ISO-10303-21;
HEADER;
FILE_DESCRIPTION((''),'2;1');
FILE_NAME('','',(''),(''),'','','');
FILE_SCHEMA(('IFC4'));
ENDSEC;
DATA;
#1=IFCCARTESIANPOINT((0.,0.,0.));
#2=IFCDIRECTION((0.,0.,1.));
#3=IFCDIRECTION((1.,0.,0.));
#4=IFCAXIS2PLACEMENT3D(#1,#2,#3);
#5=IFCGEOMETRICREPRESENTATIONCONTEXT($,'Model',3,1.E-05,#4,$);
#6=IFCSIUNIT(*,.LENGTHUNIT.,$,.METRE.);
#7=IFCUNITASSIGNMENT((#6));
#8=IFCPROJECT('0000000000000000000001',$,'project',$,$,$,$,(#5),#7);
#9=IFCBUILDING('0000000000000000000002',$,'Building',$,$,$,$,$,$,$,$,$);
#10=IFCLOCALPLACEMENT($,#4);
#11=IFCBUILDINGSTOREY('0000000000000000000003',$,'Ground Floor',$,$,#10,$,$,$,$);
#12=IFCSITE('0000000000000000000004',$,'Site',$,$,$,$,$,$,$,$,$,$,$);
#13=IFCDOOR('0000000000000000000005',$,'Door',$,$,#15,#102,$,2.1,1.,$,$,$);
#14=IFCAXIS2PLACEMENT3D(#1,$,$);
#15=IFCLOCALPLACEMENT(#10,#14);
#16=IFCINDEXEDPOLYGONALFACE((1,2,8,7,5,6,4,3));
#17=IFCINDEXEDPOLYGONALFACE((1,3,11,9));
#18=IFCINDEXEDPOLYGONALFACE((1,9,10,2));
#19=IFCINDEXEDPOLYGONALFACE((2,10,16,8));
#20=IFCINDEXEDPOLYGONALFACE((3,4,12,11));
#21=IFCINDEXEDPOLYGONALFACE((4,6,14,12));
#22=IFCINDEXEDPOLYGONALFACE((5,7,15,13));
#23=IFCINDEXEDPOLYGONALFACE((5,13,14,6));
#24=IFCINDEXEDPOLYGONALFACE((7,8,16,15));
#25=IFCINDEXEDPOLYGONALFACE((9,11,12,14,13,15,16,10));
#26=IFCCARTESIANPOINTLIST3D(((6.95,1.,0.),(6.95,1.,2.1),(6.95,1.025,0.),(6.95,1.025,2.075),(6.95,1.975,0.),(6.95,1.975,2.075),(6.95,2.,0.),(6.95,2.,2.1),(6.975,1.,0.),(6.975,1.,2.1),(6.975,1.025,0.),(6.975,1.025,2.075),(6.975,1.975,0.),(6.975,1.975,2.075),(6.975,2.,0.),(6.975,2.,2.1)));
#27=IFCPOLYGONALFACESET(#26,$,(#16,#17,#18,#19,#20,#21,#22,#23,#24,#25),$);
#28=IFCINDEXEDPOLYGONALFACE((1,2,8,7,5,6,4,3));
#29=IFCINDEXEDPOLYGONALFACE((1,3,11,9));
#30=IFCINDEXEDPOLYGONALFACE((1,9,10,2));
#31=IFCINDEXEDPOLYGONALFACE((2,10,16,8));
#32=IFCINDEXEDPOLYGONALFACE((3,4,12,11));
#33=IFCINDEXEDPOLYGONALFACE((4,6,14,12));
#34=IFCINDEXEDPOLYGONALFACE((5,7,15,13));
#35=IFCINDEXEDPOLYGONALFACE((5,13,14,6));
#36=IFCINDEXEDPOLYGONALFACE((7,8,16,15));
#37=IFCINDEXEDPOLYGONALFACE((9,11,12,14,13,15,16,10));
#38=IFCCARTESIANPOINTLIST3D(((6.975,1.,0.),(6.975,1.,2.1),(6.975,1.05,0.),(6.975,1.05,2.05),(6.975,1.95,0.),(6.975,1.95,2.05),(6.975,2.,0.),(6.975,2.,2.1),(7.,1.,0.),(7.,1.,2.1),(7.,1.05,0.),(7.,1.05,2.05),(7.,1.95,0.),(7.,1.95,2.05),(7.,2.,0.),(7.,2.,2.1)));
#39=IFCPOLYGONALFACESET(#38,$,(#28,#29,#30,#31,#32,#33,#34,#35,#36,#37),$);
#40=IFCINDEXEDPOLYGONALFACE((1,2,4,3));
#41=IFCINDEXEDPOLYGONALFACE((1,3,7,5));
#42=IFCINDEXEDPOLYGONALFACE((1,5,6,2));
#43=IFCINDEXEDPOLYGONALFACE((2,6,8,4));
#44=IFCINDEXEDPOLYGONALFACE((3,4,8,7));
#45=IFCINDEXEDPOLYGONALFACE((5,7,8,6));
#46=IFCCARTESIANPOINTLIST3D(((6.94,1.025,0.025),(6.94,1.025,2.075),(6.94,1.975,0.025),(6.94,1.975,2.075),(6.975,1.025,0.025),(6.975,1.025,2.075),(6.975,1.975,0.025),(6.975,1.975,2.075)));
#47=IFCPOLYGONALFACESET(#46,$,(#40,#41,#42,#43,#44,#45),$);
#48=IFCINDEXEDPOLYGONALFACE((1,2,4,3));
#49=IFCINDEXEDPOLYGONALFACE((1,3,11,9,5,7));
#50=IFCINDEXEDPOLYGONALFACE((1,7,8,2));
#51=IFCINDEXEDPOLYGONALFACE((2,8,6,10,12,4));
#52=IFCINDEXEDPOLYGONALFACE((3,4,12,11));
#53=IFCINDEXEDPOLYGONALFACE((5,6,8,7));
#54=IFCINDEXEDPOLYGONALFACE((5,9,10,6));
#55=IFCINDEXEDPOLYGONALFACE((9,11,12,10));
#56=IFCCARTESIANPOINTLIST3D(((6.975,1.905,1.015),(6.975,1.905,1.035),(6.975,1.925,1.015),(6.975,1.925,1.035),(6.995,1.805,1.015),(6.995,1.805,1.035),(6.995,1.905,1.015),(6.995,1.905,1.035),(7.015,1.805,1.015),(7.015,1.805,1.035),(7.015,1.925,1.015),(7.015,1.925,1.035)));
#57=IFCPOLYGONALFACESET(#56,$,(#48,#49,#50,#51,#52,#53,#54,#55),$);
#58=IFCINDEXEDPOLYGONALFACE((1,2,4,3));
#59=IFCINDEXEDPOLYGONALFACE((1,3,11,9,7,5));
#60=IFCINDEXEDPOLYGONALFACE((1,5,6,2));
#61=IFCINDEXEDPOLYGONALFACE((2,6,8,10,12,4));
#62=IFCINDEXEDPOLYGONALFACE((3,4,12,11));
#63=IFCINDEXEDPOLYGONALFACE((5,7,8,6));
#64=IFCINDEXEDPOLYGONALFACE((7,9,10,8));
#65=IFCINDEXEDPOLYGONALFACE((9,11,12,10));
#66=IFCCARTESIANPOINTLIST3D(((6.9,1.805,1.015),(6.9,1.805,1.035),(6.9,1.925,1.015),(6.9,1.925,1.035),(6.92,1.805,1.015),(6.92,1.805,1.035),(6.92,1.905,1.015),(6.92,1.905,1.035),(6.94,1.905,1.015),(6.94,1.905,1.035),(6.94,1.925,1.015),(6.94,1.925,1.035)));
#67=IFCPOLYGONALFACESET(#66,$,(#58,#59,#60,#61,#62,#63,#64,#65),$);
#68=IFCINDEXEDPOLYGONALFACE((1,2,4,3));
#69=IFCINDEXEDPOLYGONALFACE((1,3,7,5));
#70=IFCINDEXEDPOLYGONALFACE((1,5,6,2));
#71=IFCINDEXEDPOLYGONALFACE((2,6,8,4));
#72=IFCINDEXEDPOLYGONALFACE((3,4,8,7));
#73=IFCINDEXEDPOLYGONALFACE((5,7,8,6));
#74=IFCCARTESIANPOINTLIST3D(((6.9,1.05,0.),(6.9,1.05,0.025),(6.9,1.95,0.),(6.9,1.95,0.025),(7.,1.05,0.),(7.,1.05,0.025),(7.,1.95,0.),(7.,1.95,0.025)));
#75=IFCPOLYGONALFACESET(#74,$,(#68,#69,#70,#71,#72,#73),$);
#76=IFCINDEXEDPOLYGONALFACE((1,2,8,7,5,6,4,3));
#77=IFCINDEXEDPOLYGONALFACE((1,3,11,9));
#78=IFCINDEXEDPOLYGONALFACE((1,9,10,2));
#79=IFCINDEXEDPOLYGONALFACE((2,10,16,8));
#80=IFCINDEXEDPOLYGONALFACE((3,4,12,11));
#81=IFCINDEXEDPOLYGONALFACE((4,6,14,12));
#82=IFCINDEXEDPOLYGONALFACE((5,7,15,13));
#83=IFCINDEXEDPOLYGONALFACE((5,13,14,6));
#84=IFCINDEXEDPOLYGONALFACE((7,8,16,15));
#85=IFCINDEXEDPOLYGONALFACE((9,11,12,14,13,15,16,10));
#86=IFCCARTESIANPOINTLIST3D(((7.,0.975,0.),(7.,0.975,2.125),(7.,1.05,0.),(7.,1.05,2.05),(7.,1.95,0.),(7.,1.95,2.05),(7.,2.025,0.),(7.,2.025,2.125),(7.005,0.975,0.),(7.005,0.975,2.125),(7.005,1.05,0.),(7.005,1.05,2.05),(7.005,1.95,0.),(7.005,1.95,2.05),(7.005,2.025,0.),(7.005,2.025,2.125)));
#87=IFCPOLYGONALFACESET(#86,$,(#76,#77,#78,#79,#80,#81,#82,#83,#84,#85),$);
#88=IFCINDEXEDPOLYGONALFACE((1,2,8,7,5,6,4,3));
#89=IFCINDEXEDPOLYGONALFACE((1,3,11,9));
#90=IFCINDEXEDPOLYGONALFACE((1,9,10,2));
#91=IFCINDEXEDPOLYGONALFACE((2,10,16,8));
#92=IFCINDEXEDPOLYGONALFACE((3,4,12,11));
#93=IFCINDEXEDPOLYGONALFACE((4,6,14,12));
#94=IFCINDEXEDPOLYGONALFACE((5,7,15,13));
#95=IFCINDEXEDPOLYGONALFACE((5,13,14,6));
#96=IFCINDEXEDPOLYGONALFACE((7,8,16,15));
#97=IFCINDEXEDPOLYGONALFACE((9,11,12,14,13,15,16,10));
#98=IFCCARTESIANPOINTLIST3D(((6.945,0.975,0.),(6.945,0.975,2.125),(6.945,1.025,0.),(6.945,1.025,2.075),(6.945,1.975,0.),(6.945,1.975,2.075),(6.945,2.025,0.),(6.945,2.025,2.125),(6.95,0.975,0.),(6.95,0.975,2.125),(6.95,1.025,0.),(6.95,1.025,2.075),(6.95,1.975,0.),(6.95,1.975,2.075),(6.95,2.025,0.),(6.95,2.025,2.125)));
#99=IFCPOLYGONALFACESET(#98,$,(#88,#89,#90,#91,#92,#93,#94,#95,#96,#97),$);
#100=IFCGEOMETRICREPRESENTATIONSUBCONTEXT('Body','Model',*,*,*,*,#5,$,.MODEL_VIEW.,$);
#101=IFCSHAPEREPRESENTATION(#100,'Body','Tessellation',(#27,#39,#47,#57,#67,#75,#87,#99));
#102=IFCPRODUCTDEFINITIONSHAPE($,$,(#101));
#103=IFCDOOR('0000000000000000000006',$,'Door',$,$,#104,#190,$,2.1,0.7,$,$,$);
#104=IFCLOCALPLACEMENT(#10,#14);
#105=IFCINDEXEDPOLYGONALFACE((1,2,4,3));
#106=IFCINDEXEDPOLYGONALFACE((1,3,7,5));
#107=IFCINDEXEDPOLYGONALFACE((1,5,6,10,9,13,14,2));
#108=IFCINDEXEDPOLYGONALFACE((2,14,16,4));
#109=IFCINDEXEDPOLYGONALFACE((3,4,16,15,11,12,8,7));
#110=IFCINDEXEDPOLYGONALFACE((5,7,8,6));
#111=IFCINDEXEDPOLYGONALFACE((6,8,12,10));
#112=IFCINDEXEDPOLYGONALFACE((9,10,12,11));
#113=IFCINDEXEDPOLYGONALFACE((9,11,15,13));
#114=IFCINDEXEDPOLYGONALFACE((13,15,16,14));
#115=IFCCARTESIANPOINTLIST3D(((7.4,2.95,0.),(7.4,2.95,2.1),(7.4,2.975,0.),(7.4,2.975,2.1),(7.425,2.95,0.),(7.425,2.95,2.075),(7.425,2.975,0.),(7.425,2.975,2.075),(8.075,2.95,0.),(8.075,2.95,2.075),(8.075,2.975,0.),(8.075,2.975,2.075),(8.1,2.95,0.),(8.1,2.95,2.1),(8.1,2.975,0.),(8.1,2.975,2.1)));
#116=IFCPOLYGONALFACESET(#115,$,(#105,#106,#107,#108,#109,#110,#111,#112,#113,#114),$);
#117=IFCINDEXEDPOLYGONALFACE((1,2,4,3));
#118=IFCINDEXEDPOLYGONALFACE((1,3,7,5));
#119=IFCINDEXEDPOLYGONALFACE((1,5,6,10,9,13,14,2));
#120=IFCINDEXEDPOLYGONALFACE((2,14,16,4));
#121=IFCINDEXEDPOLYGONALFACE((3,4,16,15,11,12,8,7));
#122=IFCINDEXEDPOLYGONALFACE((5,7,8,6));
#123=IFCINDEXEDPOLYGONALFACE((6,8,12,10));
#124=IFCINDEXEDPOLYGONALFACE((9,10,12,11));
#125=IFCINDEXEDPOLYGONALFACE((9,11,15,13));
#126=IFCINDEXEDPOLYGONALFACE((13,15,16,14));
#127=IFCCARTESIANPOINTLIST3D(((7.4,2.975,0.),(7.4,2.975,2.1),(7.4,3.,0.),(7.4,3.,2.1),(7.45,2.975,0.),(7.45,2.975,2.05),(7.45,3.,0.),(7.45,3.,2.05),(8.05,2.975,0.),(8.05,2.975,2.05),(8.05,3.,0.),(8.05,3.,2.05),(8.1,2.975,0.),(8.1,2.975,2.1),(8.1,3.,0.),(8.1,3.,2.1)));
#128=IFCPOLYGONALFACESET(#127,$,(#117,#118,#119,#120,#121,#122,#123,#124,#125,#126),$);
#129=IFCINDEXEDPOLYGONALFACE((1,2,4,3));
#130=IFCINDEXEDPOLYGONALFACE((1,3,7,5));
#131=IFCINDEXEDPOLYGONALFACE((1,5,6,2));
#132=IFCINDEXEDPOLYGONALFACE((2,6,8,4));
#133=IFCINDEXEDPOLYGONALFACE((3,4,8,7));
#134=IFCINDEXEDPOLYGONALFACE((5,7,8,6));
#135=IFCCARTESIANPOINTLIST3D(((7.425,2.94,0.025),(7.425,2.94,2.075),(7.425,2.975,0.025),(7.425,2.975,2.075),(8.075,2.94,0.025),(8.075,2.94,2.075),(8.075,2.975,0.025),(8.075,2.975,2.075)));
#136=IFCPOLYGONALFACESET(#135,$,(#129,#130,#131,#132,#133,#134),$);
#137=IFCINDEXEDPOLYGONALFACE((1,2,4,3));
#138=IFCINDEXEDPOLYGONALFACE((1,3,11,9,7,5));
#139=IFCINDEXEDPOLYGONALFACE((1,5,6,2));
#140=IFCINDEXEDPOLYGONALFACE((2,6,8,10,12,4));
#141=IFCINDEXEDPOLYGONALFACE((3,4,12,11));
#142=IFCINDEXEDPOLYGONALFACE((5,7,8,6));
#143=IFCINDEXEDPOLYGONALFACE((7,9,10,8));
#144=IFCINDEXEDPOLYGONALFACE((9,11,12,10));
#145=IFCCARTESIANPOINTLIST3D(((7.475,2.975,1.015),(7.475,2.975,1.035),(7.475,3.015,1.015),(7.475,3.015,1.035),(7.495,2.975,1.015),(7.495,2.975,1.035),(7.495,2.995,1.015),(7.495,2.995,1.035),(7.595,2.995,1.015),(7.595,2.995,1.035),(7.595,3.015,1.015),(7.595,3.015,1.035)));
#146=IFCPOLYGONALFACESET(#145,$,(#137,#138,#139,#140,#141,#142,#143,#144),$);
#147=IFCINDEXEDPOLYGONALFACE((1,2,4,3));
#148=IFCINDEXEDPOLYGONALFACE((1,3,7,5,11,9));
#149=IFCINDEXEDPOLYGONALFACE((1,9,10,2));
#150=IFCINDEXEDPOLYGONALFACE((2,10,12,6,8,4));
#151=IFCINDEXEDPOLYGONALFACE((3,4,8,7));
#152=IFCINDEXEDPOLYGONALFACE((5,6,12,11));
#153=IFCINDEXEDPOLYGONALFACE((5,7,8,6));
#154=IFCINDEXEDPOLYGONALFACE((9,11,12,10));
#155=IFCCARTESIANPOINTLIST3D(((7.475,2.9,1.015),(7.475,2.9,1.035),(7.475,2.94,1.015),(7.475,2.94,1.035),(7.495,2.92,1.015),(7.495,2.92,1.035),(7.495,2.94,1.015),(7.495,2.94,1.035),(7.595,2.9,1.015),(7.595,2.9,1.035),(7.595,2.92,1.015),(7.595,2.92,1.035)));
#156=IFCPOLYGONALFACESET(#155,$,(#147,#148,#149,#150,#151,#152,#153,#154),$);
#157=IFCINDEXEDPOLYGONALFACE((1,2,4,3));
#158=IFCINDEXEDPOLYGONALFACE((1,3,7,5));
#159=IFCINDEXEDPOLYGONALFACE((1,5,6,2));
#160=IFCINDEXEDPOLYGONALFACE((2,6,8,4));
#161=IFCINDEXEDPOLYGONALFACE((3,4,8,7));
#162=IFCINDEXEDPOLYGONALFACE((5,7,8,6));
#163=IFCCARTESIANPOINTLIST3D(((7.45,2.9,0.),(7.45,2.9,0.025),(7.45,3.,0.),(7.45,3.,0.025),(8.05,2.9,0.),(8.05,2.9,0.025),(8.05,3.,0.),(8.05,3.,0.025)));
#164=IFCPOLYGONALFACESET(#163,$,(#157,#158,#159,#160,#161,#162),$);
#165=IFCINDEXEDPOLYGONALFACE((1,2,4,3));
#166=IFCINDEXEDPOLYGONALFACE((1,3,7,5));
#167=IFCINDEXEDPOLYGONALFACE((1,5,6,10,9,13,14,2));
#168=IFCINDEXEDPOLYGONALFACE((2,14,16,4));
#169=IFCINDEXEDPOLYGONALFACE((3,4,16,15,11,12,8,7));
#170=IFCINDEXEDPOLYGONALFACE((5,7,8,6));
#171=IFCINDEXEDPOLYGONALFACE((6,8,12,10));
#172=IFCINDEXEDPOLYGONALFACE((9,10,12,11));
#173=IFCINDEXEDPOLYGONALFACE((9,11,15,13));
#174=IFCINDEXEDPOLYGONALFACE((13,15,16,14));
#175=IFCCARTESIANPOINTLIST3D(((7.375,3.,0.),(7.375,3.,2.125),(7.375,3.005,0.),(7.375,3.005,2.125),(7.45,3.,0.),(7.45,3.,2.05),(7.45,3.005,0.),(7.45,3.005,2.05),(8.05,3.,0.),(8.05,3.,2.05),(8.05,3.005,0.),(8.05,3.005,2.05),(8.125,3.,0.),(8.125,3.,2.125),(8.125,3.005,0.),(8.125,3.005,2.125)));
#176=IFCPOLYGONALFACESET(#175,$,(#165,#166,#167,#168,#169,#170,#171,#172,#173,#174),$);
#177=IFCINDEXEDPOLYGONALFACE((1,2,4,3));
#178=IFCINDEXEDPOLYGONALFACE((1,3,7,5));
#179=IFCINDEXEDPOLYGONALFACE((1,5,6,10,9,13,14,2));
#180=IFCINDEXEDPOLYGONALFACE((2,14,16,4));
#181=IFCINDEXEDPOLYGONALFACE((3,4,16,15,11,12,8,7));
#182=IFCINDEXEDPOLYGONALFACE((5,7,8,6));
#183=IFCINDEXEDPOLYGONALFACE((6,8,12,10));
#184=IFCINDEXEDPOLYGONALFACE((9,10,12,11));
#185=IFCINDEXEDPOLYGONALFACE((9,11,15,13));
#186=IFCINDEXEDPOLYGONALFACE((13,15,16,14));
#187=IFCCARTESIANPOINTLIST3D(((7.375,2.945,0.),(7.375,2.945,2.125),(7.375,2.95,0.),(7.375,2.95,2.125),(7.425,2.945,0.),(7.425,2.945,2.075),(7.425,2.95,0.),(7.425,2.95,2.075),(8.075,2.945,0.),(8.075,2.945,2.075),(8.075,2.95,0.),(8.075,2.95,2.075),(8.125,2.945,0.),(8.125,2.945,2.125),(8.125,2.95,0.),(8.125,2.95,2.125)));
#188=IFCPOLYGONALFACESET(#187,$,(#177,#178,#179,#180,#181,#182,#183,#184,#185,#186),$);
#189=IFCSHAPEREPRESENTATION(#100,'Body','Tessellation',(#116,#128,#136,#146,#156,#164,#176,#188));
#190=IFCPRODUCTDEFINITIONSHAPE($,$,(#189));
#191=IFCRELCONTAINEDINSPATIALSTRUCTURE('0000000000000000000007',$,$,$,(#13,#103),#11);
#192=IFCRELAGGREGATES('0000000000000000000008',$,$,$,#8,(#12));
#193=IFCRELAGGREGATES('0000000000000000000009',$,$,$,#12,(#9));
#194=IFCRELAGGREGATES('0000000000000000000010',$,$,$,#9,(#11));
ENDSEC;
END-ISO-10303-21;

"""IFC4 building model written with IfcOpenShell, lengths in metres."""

from ifc_helpers import new_model, si_unit, frame, origin_with_axes, place, context, subcontext, project, spatial, line, indexed_curve, outline, extrude, element, save


model = new_model("IFC4")

# Units and contexts
model_context = context("Model", 3, precision=1e-05, world=origin_with_axes())
body_context = subcontext(model_context, "Body", "Model", "MODEL_VIEW")
ifc_project = project(units=[si_unit("LENGTHUNIT", "METRE")], contexts=[model_context])

# Site, building, storey
site = spatial("IfcSite", under=ifc_project, Name="Site")
building = spatial("IfcBuilding", under=site, Name="Building")
storey_placement = place(None, origin_with_axes())
storey = spatial("IfcBuildingStorey", under=building, at=storey_placement, Name="Ground Floor")

# Doors
door_1_placement = place(storey_placement, frame((7.0, 1.0, 0.0), z_axis=(0.0, 0.0, 1.0), x_axis=(0.0, 1.0, 0.0)))
element("IfcDoor", 1, at=door_1_placement, inside=storey, Name="Door", OverallHeight=2.1, OverallWidth=1.0, context=body_context, shape_type="SweptSolid", body=[
    extrude(outline(indexed_curve([(0.0, 0.0), (0.0, 2.1), (1.0, 2.1), (1.0, 0.0), (0.975, 0.0), (0.975, 2.075), (0.025, 2.075), (0.025, 0.0)], segments=[line(1, 2, 3, 4, 5, 6, 7, 8, 1)])), frame((0.0, 0.025, 0.0), z_axis=(0.0, -1.0, 0.0), x_axis=(1.0, 0.0, 0.0)), (0.0, 0.0, -1.0), 0.025),
    extrude(outline(indexed_curve([(0.0, 0.0), (0.0, 2.1), (1.0, 2.1), (1.0, 0.0), (0.95, 0.0), (0.95, 2.05), (0.05, 2.05), (0.05, 0.0)], segments=[line(1, 2, 3, 4, 5, 6, 7, 8, 1)])), frame((0.0, 0.0, 0.0), z_axis=(0.0, -1.0, 0.0), x_axis=(1.0, 0.0, 0.0)), (0.0, 0.0, -1.0), 0.025),
    extrude(outline(indexed_curve([(0.0, 0.0), (0.95, 0.0), (0.95, 0.035), (0.0, 0.035)], segments=[line(1, 2, 3, 4, 1)])), frame((0.025, 0.025, 0.025), z_axis=(0.0, 0.0, 1.0), x_axis=(1.0, 0.0, 0.0)), (0.0, 0.0, 1.0), 2.05),
    extrude(outline(indexed_curve([(0.0, 0.0), (0.0, -0.04), (-0.12, -0.04), (-0.12, -0.02), (-0.02, -0.02), (-0.02, 0.0)], segments=[line(1, 2, 3, 4, 5, 6, 1)])), frame((0.925, 0.025, 1.015), z_axis=(0.0, 0.0, 1.0), x_axis=(1.0, 0.0, 0.0)), (0.0, 0.0, 1.0), 0.02),
    extrude(outline(indexed_curve([(0.0, 0.0), (0.0, 0.04), (-0.12, 0.04), (-0.12, 0.02), (-0.02, 0.02), (-0.02, 0.0)], segments=[line(1, 2, 3, 4, 5, 6, 1)])), frame((0.925, 0.06, 1.015), z_axis=(0.0, 0.0, 1.0), x_axis=(1.0, 0.0, 0.0)), (0.0, 0.0, 1.0), 0.02),
    extrude(outline(indexed_curve([(0.0, 0.0), (0.9, 0.0), (0.9, 0.1), (0.0, 0.1)], segments=[line(1, 2, 3, 4, 1)])), frame((0.05, 0.0, 0.0), z_axis=(0.0, 0.0, 1.0), x_axis=(1.0, 0.0, 0.0)), (0.0, 0.0, 1.0), 0.025),
    extrude(outline(indexed_curve([(0.0, 0.0), (0.0, 2.125), (1.05, 2.125), (1.05, 0.0), (0.975, 0.0), (0.975, 2.05), (0.075, 2.05), (0.075, 0.0)], segments=[line(1, 2, 3, 4, 5, 6, 7, 8, 1)])), frame((-0.025, -0.005, 0.0), z_axis=(0.0, -1.0, 0.0), x_axis=(1.0, 0.0, 0.0)), (0.0, 0.0, -1.0), 0.005),
    extrude(outline(indexed_curve([(0.0, 0.0), (0.0, 2.125), (1.05, 2.125), (1.05, 0.0), (1.0, 0.0), (1.0, 2.075), (0.05, 2.075), (0.05, 0.0)], segments=[line(1, 2, 3, 4, 5, 6, 7, 8, 1)])), frame((-0.025, 0.05, 0.0), z_axis=(0.0, -1.0, 0.0), x_axis=(1.0, 0.0, 0.0)), (0.0, 0.0, -1.0), 0.005),
])
door_2_placement = place(storey_placement, frame((8.1, 3.0, 0.0), z_axis=(0.0, 0.0, 1.0), x_axis=(-1.0, 0.0, 0.0)))
element("IfcDoor", 2, at=door_2_placement, inside=storey, Name="Door", OverallHeight=2.1, OverallWidth=0.7, context=body_context, shape_type="SweptSolid", body=[
    extrude(outline(indexed_curve([(0.0, 0.0), (0.0, 2.1), (0.7, 2.1), (0.7, 0.0), (0.675, 0.0), (0.675, 2.075), (0.025, 2.075), (0.025, 0.0)], segments=[line(1, 2, 3, 4, 5, 6, 7, 8, 1)])), frame((0.0, 0.025, 0.0), z_axis=(0.0, -1.0, 0.0), x_axis=(1.0, 0.0, 0.0)), (0.0, 0.0, -1.0), 0.025),
    extrude(outline(indexed_curve([(0.0, 0.0), (0.0, 2.1), (0.7, 2.1), (0.7, 0.0), (0.65, 0.0), (0.65, 2.05), (0.05, 2.05), (0.05, 0.0)], segments=[line(1, 2, 3, 4, 5, 6, 7, 8, 1)])), frame((0.0, 0.0, 0.0), z_axis=(0.0, -1.0, 0.0), x_axis=(1.0, 0.0, 0.0)), (0.0, 0.0, -1.0), 0.025),
    extrude(outline(indexed_curve([(0.0, 0.0), (0.65, 0.0), (0.65, 0.035), (0.0, 0.035)], segments=[line(1, 2, 3, 4, 1)])), frame((0.025, 0.025, 0.025), z_axis=(0.0, 0.0, 1.0), x_axis=(1.0, 0.0, 0.0)), (0.0, 0.0, 1.0), 2.05),
    extrude(outline(indexed_curve([(0.0, 0.0), (0.0, -0.04), (-0.12, -0.04), (-0.12, -0.02), (-0.02, -0.02), (-0.02, 0.0)], segments=[line(1, 2, 3, 4, 5, 6, 1)])), frame((0.625, 0.025, 1.015), z_axis=(0.0, 0.0, 1.0), x_axis=(1.0, 0.0, 0.0)), (0.0, 0.0, 1.0), 0.02),
    extrude(outline(indexed_curve([(0.0, 0.0), (0.0, 0.04), (-0.12, 0.04), (-0.12, 0.02), (-0.02, 0.02), (-0.02, 0.0)], segments=[line(1, 2, 3, 4, 5, 6, 1)])), frame((0.625, 0.06, 1.015), z_axis=(0.0, 0.0, 1.0), x_axis=(1.0, 0.0, 0.0)), (0.0, 0.0, 1.0), 0.02),
    extrude(outline(indexed_curve([(0.0, 0.0), (0.6, 0.0), (0.6, 0.1), (0.0, 0.1)], segments=[line(1, 2, 3, 4, 1)])), frame((0.05, 0.0, 0.0), z_axis=(0.0, 0.0, 1.0), x_axis=(1.0, 0.0, 0.0)), (0.0, 0.0, 1.0), 0.025),
    extrude(outline(indexed_curve([(0.0, 0.0), (0.0, 2.125), (0.75, 2.125), (0.75, 0.0), (0.675, 0.0), (0.675, 2.05), (0.075, 2.05), (0.075, 0.0)], segments=[line(1, 2, 3, 4, 5, 6, 7, 8, 1)])), frame((-0.025, -0.005, 0.0), z_axis=(0.0, -1.0, 0.0), x_axis=(1.0, 0.0, 0.0)), (0.0, 0.0, -1.0), 0.005),
    extrude(outline(indexed_curve([(0.0, 0.0), (0.0, 2.125), (0.75, 2.125), (0.75, 0.0), (0.7, 0.0), (0.7, 2.075), (0.05, 2.075), (0.05, 0.0)], segments=[line(1, 2, 3, 4, 5, 6, 7, 8, 1)])), frame((-0.025, 0.05, 0.0), z_axis=(0.0, -1.0, 0.0), x_axis=(1.0, 0.0, 0.0)), (0.0, 0.0, -1.0), 0.005),
])

save(model, "model.ifc")
